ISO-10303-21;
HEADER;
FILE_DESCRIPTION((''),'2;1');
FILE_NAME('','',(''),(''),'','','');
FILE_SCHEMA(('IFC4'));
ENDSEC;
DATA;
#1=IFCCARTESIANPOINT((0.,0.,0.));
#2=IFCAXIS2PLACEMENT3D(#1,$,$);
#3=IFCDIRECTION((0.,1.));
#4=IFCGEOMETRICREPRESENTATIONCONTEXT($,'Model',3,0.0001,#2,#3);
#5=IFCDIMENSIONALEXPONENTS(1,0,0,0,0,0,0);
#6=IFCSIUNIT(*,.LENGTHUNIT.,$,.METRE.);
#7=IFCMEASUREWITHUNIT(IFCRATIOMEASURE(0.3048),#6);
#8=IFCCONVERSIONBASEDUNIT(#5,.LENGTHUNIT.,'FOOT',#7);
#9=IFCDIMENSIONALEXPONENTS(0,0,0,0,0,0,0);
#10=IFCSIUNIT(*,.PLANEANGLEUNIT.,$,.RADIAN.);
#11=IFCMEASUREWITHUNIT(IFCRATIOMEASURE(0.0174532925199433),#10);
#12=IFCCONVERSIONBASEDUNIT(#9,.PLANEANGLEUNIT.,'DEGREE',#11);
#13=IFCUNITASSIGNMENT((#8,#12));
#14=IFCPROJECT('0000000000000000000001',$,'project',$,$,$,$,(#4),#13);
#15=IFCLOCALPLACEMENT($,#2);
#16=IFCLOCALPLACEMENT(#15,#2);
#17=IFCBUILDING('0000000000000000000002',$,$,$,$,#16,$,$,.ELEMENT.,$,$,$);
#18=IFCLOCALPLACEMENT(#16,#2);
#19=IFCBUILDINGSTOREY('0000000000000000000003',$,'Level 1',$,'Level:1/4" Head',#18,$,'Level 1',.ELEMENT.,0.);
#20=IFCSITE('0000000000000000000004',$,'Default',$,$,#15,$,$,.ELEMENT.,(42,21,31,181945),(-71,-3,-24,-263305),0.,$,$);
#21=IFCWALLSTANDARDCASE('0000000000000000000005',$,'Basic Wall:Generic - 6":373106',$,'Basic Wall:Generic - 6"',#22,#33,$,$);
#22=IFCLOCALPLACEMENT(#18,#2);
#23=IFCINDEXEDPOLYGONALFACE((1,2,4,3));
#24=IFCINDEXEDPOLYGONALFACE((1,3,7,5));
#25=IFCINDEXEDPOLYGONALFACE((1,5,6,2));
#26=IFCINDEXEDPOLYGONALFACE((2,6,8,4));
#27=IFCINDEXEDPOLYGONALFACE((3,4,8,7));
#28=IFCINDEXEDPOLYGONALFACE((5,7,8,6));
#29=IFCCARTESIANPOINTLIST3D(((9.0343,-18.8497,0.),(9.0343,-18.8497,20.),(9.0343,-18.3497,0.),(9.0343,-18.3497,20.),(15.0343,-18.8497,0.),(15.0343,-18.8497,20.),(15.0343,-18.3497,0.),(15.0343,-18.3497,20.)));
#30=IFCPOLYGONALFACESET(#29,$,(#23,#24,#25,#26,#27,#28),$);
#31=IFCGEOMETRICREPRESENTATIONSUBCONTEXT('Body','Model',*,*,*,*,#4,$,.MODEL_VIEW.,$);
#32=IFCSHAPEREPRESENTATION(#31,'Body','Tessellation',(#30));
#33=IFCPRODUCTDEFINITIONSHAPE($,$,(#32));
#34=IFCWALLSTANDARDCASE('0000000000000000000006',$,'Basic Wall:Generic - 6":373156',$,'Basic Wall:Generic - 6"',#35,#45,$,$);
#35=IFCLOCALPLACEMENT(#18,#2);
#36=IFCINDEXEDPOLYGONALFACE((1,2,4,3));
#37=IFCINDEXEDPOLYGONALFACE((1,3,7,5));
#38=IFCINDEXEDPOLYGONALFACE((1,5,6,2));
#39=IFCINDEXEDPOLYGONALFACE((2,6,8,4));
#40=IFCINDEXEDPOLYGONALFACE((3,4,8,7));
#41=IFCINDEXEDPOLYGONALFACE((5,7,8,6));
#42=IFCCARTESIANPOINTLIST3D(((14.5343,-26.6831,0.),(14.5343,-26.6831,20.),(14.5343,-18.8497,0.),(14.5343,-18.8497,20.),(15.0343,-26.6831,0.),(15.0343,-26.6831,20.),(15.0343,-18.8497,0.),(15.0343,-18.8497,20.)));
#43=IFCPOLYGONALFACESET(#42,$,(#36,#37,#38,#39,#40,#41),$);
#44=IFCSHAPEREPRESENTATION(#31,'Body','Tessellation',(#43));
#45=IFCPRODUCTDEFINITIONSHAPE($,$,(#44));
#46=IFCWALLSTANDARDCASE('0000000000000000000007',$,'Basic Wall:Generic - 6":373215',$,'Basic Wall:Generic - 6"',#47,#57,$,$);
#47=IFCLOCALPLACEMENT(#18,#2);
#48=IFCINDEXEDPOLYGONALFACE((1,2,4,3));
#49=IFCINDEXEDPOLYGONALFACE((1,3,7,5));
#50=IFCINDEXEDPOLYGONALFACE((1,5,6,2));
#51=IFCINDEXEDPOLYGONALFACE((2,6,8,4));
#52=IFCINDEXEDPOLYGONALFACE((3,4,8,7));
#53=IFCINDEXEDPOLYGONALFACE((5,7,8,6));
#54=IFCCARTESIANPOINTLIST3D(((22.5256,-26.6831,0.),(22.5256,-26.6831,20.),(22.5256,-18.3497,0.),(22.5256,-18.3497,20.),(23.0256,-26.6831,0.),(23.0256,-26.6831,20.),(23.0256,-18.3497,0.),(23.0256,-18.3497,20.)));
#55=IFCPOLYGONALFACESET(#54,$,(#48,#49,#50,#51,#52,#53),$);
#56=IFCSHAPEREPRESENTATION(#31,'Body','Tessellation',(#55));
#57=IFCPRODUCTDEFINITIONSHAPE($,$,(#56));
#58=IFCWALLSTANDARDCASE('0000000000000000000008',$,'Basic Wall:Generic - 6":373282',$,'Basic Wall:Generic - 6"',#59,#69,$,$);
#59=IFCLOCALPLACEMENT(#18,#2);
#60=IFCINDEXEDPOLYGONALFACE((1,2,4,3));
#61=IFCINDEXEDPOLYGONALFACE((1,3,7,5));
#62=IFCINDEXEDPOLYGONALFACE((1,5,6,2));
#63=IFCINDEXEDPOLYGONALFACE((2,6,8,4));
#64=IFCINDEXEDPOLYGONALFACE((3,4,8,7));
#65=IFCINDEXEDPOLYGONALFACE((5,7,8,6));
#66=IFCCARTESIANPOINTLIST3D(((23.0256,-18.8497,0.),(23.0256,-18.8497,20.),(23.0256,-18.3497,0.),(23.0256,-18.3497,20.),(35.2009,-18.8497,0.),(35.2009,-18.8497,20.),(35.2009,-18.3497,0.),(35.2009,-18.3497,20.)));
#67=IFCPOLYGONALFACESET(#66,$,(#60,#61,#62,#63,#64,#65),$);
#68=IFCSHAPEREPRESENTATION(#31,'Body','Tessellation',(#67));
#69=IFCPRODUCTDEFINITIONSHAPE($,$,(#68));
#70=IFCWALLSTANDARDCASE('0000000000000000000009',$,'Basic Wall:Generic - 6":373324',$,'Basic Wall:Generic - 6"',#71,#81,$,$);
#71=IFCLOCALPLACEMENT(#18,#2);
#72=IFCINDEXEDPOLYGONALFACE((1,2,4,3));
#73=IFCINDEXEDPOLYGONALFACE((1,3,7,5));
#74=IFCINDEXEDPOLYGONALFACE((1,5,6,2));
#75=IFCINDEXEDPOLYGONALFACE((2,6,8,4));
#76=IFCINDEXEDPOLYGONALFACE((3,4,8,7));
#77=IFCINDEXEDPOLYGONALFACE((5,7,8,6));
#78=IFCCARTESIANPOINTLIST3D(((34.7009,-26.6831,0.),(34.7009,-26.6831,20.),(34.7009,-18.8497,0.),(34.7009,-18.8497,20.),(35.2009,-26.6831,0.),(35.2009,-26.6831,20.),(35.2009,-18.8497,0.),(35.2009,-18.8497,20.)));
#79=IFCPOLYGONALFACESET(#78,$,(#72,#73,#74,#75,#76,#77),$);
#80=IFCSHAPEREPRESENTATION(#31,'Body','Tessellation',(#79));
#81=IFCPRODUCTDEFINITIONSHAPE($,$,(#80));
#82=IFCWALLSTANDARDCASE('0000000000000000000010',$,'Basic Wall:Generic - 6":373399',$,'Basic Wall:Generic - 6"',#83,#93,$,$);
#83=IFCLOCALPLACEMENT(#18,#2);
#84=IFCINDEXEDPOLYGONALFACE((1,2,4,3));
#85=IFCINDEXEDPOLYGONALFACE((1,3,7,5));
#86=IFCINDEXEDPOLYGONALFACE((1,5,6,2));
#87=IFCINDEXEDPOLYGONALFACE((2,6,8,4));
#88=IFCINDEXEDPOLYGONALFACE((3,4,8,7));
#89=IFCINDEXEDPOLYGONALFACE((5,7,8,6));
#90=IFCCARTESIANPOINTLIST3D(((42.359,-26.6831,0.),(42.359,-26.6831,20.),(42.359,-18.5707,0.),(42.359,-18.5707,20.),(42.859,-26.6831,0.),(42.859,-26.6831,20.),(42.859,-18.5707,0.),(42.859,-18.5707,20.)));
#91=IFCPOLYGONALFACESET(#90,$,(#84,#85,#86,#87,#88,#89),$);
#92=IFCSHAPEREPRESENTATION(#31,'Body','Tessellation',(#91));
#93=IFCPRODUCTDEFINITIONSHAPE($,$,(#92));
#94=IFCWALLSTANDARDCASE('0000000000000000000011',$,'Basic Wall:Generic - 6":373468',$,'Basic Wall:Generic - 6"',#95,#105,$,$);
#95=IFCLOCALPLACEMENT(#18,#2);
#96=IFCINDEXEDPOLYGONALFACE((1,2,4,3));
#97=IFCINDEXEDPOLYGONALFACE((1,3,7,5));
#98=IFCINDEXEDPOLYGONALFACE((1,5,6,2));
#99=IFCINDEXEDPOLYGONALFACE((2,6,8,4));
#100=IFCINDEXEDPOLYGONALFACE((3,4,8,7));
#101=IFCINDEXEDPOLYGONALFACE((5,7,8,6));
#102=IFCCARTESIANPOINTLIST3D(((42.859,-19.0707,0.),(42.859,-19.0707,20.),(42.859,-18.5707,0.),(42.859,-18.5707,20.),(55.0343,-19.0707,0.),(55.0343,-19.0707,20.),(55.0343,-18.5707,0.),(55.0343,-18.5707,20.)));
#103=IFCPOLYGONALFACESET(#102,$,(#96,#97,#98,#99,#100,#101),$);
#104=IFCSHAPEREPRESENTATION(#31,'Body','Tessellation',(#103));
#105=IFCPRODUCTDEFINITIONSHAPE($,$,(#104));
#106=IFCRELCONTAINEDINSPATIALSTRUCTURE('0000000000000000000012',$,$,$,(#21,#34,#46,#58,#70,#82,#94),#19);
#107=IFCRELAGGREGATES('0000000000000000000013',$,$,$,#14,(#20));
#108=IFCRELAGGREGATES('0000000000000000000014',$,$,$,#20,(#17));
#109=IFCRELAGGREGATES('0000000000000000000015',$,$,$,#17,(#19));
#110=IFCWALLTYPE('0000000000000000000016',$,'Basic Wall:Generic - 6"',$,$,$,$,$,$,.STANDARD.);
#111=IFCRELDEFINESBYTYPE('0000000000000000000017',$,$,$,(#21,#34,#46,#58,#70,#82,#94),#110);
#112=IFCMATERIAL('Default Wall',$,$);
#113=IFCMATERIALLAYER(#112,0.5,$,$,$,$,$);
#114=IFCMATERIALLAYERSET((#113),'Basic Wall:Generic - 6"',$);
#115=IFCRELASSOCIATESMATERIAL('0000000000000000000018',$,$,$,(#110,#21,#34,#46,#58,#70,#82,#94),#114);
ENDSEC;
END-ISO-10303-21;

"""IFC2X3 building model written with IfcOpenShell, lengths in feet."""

from ifc_helpers import new_model, entity, si_unit, converted_unit, direction, frame, frame_2d, origin, place, context, subcontext, project, spatial, rectangle, extrude, material, layer, layer_set, layer_usage, type_object, element, save


model = new_model("IFC2X3")

# Units and contexts
model_context = context("Model", 3, precision=0.0001, world=origin(), true_north=direction((0.0, 1.0)))
body_context = subcontext(model_context, "Body", "Model", "MODEL_VIEW")
ifc_project = project(units=[converted_unit("LENGTHUNIT", "FOOT", entity("IfcRatioMeasure", 0.3048), si_unit("LENGTHUNIT", "METRE"), dimensions=[1, 0, 0, 0, 0, 0, 0]), converted_unit("PLANEANGLEUNIT", "DEGREE", entity("IfcRatioMeasure", 0.0174532925199433), si_unit("PLANEANGLEUNIT", "RADIAN"), dimensions=[0, 0, 0, 0, 0, 0, 0])], contexts=[model_context])

# Site, building, storey
site_placement = place(None, origin())
site = spatial("IfcSite", under=ifc_project, at=site_placement, Name="Default", CompositionType="ELEMENT", RefLatitude=(42, 21, 31, 181945), RefLongitude=(-71, -3, -24, -263305), RefElevation=0.0)
building_placement = place(site_placement, origin())
building = spatial("IfcBuilding", under=site, at=building_placement, CompositionType="ELEMENT")
storey_placement = place(building_placement, origin())
storey = spatial("IfcBuildingStorey", under=building, at=storey_placement, Name="Level 1", ObjectType="Level:1/4\" Head", LongName="Level 1", CompositionType="ELEMENT", Elevation=0.0)

# Walls
ifc_material = material(Name="Default Wall")
ifc_layer = layer(ifc_material, 0.5)
ifc_layer_set = layer_set([ifc_layer], Name="Basic Wall:Generic - 6\"")
wall_type = type_object("IfcWallType", Name="Basic Wall:Generic - 6\"", PredefinedType="STANDARD", material=ifc_layer_set)
ifc_layer_usage_1 = layer_usage(ifc_layer_set, "AXIS2", "NEGATIVE", 0.25)
wall_1_placement = place(storey_placement, frame((9.0343, -18.5997, 0.0)))
element("IfcWallStandardCase", 1, at=wall_1_placement, inside=storey, type_object=wall_type, material=ifc_layer_usage_1, Name="Basic Wall:Generic - 6\":373106", ObjectType="Basic Wall:Generic - 6\"", context=body_context, shape_type="SweptSolid", body=[
    extrude(rectangle(XDim=6.0, YDim=0.5, at=frame_2d((3.0, 0.0), x_axis=(-1.0, 0.0))), origin(), (0.0, 0.0, 1.0), 20.0),
])
ifc_layer_usage_2 = layer_usage(ifc_layer_set, "AXIS2", "NEGATIVE", 0.25)
wall_2_placement = place(storey_placement, frame((14.7843, -18.8497, 0.0), z_axis=(0.0, 0.0, 1.0), x_axis=(0.0, -1.0, 0.0)))
element("IfcWallStandardCase", 2, at=wall_2_placement, inside=storey, type_object=wall_type, material=ifc_layer_usage_2, Name="Basic Wall:Generic - 6\":373156", ObjectType="Basic Wall:Generic - 6\"", context=body_context, shape_type="SweptSolid", body=[
    extrude(rectangle(XDim=7.8333, YDim=0.5, at=frame_2d((3.9167, 0.0), x_axis=(-1.0, 0.0))), origin(), (0.0, 0.0, 1.0), 20.0),
])
ifc_layer_usage_3 = layer_usage(ifc_layer_set, "AXIS2", "NEGATIVE", 0.25)
wall_3_placement = place(storey_placement, frame((22.7756, -26.6831, 0.0), z_axis=(0.0, 0.0, 1.0), x_axis=(0.0, 1.0, 0.0)))
element("IfcWallStandardCase", 3, at=wall_3_placement, inside=storey, type_object=wall_type, material=ifc_layer_usage_3, Name="Basic Wall:Generic - 6\":373215", ObjectType="Basic Wall:Generic - 6\"", context=body_context, shape_type="SweptSolid", body=[
    extrude(rectangle(XDim=8.3333, YDim=0.5, at=frame_2d((4.1667, 0.0), x_axis=(-1.0, 0.0))), origin(), (0.0, 0.0, 1.0), 20.0),
])
ifc_layer_usage_4 = layer_usage(ifc_layer_set, "AXIS2", "NEGATIVE", 0.25)
wall_4_placement = place(storey_placement, frame((23.0256, -18.5997, 0.0)))
element("IfcWallStandardCase", 4, at=wall_4_placement, inside=storey, type_object=wall_type, material=ifc_layer_usage_4, Name="Basic Wall:Generic - 6\":373282", ObjectType="Basic Wall:Generic - 6\"", context=body_context, shape_type="SweptSolid", body=[
    extrude(rectangle(XDim=12.1753, YDim=0.5, at=frame_2d((6.0876, 0.0), x_axis=(-1.0, 0.0))), origin(), (0.0, 0.0, 1.0), 20.0),
])
ifc_layer_usage_5 = layer_usage(ifc_layer_set, "AXIS2", "NEGATIVE", 0.25)
wall_5_placement = place(storey_placement, frame((34.9509, -18.8497, 0.0), z_axis=(0.0, 0.0, 1.0), x_axis=(0.0, -1.0, 0.0)))
element("IfcWallStandardCase", 5, at=wall_5_placement, inside=storey, type_object=wall_type, material=ifc_layer_usage_5, Name="Basic Wall:Generic - 6\":373324", ObjectType="Basic Wall:Generic - 6\"", context=body_context, shape_type="SweptSolid", body=[
    extrude(rectangle(XDim=7.8333, YDim=0.5, at=frame_2d((3.9167, 0.0), x_axis=(-1.0, 0.0))), origin(), (0.0, 0.0, 1.0), 20.0),
])
ifc_layer_usage_6 = layer_usage(ifc_layer_set, "AXIS2", "NEGATIVE", 0.25)
wall_6_placement = place(storey_placement, frame((42.609, -26.6831, 0.0), z_axis=(0.0, 0.0, 1.0), x_axis=(0.0, 1.0, 0.0)))
element("IfcWallStandardCase", 6, at=wall_6_placement, inside=storey, type_object=wall_type, material=ifc_layer_usage_6, Name="Basic Wall:Generic - 6\":373399", ObjectType="Basic Wall:Generic - 6\"", context=body_context, shape_type="SweptSolid", body=[
    extrude(rectangle(XDim=8.1123, YDim=0.5, at=frame_2d((4.0562, 0.0), x_axis=(-1.0, 0.0))), origin(), (0.0, 0.0, 1.0), 20.0),
])
ifc_layer_usage_7 = layer_usage(ifc_layer_set, "AXIS2", "NEGATIVE", 0.25)
wall_7_placement = place(storey_placement, frame((42.859, -18.8207, 0.0)))
element("IfcWallStandardCase", 7, at=wall_7_placement, inside=storey, type_object=wall_type, material=ifc_layer_usage_7, Name="Basic Wall:Generic - 6\":373468", ObjectType="Basic Wall:Generic - 6\"", context=body_context, shape_type="SweptSolid", body=[
    extrude(rectangle(XDim=12.1753, YDim=0.5, at=frame_2d((6.0876, 0.0), x_axis=(-1.0, 0.0))), origin(), (0.0, 0.0, 1.0), 20.0),
])

save(model, "model.ifc")
